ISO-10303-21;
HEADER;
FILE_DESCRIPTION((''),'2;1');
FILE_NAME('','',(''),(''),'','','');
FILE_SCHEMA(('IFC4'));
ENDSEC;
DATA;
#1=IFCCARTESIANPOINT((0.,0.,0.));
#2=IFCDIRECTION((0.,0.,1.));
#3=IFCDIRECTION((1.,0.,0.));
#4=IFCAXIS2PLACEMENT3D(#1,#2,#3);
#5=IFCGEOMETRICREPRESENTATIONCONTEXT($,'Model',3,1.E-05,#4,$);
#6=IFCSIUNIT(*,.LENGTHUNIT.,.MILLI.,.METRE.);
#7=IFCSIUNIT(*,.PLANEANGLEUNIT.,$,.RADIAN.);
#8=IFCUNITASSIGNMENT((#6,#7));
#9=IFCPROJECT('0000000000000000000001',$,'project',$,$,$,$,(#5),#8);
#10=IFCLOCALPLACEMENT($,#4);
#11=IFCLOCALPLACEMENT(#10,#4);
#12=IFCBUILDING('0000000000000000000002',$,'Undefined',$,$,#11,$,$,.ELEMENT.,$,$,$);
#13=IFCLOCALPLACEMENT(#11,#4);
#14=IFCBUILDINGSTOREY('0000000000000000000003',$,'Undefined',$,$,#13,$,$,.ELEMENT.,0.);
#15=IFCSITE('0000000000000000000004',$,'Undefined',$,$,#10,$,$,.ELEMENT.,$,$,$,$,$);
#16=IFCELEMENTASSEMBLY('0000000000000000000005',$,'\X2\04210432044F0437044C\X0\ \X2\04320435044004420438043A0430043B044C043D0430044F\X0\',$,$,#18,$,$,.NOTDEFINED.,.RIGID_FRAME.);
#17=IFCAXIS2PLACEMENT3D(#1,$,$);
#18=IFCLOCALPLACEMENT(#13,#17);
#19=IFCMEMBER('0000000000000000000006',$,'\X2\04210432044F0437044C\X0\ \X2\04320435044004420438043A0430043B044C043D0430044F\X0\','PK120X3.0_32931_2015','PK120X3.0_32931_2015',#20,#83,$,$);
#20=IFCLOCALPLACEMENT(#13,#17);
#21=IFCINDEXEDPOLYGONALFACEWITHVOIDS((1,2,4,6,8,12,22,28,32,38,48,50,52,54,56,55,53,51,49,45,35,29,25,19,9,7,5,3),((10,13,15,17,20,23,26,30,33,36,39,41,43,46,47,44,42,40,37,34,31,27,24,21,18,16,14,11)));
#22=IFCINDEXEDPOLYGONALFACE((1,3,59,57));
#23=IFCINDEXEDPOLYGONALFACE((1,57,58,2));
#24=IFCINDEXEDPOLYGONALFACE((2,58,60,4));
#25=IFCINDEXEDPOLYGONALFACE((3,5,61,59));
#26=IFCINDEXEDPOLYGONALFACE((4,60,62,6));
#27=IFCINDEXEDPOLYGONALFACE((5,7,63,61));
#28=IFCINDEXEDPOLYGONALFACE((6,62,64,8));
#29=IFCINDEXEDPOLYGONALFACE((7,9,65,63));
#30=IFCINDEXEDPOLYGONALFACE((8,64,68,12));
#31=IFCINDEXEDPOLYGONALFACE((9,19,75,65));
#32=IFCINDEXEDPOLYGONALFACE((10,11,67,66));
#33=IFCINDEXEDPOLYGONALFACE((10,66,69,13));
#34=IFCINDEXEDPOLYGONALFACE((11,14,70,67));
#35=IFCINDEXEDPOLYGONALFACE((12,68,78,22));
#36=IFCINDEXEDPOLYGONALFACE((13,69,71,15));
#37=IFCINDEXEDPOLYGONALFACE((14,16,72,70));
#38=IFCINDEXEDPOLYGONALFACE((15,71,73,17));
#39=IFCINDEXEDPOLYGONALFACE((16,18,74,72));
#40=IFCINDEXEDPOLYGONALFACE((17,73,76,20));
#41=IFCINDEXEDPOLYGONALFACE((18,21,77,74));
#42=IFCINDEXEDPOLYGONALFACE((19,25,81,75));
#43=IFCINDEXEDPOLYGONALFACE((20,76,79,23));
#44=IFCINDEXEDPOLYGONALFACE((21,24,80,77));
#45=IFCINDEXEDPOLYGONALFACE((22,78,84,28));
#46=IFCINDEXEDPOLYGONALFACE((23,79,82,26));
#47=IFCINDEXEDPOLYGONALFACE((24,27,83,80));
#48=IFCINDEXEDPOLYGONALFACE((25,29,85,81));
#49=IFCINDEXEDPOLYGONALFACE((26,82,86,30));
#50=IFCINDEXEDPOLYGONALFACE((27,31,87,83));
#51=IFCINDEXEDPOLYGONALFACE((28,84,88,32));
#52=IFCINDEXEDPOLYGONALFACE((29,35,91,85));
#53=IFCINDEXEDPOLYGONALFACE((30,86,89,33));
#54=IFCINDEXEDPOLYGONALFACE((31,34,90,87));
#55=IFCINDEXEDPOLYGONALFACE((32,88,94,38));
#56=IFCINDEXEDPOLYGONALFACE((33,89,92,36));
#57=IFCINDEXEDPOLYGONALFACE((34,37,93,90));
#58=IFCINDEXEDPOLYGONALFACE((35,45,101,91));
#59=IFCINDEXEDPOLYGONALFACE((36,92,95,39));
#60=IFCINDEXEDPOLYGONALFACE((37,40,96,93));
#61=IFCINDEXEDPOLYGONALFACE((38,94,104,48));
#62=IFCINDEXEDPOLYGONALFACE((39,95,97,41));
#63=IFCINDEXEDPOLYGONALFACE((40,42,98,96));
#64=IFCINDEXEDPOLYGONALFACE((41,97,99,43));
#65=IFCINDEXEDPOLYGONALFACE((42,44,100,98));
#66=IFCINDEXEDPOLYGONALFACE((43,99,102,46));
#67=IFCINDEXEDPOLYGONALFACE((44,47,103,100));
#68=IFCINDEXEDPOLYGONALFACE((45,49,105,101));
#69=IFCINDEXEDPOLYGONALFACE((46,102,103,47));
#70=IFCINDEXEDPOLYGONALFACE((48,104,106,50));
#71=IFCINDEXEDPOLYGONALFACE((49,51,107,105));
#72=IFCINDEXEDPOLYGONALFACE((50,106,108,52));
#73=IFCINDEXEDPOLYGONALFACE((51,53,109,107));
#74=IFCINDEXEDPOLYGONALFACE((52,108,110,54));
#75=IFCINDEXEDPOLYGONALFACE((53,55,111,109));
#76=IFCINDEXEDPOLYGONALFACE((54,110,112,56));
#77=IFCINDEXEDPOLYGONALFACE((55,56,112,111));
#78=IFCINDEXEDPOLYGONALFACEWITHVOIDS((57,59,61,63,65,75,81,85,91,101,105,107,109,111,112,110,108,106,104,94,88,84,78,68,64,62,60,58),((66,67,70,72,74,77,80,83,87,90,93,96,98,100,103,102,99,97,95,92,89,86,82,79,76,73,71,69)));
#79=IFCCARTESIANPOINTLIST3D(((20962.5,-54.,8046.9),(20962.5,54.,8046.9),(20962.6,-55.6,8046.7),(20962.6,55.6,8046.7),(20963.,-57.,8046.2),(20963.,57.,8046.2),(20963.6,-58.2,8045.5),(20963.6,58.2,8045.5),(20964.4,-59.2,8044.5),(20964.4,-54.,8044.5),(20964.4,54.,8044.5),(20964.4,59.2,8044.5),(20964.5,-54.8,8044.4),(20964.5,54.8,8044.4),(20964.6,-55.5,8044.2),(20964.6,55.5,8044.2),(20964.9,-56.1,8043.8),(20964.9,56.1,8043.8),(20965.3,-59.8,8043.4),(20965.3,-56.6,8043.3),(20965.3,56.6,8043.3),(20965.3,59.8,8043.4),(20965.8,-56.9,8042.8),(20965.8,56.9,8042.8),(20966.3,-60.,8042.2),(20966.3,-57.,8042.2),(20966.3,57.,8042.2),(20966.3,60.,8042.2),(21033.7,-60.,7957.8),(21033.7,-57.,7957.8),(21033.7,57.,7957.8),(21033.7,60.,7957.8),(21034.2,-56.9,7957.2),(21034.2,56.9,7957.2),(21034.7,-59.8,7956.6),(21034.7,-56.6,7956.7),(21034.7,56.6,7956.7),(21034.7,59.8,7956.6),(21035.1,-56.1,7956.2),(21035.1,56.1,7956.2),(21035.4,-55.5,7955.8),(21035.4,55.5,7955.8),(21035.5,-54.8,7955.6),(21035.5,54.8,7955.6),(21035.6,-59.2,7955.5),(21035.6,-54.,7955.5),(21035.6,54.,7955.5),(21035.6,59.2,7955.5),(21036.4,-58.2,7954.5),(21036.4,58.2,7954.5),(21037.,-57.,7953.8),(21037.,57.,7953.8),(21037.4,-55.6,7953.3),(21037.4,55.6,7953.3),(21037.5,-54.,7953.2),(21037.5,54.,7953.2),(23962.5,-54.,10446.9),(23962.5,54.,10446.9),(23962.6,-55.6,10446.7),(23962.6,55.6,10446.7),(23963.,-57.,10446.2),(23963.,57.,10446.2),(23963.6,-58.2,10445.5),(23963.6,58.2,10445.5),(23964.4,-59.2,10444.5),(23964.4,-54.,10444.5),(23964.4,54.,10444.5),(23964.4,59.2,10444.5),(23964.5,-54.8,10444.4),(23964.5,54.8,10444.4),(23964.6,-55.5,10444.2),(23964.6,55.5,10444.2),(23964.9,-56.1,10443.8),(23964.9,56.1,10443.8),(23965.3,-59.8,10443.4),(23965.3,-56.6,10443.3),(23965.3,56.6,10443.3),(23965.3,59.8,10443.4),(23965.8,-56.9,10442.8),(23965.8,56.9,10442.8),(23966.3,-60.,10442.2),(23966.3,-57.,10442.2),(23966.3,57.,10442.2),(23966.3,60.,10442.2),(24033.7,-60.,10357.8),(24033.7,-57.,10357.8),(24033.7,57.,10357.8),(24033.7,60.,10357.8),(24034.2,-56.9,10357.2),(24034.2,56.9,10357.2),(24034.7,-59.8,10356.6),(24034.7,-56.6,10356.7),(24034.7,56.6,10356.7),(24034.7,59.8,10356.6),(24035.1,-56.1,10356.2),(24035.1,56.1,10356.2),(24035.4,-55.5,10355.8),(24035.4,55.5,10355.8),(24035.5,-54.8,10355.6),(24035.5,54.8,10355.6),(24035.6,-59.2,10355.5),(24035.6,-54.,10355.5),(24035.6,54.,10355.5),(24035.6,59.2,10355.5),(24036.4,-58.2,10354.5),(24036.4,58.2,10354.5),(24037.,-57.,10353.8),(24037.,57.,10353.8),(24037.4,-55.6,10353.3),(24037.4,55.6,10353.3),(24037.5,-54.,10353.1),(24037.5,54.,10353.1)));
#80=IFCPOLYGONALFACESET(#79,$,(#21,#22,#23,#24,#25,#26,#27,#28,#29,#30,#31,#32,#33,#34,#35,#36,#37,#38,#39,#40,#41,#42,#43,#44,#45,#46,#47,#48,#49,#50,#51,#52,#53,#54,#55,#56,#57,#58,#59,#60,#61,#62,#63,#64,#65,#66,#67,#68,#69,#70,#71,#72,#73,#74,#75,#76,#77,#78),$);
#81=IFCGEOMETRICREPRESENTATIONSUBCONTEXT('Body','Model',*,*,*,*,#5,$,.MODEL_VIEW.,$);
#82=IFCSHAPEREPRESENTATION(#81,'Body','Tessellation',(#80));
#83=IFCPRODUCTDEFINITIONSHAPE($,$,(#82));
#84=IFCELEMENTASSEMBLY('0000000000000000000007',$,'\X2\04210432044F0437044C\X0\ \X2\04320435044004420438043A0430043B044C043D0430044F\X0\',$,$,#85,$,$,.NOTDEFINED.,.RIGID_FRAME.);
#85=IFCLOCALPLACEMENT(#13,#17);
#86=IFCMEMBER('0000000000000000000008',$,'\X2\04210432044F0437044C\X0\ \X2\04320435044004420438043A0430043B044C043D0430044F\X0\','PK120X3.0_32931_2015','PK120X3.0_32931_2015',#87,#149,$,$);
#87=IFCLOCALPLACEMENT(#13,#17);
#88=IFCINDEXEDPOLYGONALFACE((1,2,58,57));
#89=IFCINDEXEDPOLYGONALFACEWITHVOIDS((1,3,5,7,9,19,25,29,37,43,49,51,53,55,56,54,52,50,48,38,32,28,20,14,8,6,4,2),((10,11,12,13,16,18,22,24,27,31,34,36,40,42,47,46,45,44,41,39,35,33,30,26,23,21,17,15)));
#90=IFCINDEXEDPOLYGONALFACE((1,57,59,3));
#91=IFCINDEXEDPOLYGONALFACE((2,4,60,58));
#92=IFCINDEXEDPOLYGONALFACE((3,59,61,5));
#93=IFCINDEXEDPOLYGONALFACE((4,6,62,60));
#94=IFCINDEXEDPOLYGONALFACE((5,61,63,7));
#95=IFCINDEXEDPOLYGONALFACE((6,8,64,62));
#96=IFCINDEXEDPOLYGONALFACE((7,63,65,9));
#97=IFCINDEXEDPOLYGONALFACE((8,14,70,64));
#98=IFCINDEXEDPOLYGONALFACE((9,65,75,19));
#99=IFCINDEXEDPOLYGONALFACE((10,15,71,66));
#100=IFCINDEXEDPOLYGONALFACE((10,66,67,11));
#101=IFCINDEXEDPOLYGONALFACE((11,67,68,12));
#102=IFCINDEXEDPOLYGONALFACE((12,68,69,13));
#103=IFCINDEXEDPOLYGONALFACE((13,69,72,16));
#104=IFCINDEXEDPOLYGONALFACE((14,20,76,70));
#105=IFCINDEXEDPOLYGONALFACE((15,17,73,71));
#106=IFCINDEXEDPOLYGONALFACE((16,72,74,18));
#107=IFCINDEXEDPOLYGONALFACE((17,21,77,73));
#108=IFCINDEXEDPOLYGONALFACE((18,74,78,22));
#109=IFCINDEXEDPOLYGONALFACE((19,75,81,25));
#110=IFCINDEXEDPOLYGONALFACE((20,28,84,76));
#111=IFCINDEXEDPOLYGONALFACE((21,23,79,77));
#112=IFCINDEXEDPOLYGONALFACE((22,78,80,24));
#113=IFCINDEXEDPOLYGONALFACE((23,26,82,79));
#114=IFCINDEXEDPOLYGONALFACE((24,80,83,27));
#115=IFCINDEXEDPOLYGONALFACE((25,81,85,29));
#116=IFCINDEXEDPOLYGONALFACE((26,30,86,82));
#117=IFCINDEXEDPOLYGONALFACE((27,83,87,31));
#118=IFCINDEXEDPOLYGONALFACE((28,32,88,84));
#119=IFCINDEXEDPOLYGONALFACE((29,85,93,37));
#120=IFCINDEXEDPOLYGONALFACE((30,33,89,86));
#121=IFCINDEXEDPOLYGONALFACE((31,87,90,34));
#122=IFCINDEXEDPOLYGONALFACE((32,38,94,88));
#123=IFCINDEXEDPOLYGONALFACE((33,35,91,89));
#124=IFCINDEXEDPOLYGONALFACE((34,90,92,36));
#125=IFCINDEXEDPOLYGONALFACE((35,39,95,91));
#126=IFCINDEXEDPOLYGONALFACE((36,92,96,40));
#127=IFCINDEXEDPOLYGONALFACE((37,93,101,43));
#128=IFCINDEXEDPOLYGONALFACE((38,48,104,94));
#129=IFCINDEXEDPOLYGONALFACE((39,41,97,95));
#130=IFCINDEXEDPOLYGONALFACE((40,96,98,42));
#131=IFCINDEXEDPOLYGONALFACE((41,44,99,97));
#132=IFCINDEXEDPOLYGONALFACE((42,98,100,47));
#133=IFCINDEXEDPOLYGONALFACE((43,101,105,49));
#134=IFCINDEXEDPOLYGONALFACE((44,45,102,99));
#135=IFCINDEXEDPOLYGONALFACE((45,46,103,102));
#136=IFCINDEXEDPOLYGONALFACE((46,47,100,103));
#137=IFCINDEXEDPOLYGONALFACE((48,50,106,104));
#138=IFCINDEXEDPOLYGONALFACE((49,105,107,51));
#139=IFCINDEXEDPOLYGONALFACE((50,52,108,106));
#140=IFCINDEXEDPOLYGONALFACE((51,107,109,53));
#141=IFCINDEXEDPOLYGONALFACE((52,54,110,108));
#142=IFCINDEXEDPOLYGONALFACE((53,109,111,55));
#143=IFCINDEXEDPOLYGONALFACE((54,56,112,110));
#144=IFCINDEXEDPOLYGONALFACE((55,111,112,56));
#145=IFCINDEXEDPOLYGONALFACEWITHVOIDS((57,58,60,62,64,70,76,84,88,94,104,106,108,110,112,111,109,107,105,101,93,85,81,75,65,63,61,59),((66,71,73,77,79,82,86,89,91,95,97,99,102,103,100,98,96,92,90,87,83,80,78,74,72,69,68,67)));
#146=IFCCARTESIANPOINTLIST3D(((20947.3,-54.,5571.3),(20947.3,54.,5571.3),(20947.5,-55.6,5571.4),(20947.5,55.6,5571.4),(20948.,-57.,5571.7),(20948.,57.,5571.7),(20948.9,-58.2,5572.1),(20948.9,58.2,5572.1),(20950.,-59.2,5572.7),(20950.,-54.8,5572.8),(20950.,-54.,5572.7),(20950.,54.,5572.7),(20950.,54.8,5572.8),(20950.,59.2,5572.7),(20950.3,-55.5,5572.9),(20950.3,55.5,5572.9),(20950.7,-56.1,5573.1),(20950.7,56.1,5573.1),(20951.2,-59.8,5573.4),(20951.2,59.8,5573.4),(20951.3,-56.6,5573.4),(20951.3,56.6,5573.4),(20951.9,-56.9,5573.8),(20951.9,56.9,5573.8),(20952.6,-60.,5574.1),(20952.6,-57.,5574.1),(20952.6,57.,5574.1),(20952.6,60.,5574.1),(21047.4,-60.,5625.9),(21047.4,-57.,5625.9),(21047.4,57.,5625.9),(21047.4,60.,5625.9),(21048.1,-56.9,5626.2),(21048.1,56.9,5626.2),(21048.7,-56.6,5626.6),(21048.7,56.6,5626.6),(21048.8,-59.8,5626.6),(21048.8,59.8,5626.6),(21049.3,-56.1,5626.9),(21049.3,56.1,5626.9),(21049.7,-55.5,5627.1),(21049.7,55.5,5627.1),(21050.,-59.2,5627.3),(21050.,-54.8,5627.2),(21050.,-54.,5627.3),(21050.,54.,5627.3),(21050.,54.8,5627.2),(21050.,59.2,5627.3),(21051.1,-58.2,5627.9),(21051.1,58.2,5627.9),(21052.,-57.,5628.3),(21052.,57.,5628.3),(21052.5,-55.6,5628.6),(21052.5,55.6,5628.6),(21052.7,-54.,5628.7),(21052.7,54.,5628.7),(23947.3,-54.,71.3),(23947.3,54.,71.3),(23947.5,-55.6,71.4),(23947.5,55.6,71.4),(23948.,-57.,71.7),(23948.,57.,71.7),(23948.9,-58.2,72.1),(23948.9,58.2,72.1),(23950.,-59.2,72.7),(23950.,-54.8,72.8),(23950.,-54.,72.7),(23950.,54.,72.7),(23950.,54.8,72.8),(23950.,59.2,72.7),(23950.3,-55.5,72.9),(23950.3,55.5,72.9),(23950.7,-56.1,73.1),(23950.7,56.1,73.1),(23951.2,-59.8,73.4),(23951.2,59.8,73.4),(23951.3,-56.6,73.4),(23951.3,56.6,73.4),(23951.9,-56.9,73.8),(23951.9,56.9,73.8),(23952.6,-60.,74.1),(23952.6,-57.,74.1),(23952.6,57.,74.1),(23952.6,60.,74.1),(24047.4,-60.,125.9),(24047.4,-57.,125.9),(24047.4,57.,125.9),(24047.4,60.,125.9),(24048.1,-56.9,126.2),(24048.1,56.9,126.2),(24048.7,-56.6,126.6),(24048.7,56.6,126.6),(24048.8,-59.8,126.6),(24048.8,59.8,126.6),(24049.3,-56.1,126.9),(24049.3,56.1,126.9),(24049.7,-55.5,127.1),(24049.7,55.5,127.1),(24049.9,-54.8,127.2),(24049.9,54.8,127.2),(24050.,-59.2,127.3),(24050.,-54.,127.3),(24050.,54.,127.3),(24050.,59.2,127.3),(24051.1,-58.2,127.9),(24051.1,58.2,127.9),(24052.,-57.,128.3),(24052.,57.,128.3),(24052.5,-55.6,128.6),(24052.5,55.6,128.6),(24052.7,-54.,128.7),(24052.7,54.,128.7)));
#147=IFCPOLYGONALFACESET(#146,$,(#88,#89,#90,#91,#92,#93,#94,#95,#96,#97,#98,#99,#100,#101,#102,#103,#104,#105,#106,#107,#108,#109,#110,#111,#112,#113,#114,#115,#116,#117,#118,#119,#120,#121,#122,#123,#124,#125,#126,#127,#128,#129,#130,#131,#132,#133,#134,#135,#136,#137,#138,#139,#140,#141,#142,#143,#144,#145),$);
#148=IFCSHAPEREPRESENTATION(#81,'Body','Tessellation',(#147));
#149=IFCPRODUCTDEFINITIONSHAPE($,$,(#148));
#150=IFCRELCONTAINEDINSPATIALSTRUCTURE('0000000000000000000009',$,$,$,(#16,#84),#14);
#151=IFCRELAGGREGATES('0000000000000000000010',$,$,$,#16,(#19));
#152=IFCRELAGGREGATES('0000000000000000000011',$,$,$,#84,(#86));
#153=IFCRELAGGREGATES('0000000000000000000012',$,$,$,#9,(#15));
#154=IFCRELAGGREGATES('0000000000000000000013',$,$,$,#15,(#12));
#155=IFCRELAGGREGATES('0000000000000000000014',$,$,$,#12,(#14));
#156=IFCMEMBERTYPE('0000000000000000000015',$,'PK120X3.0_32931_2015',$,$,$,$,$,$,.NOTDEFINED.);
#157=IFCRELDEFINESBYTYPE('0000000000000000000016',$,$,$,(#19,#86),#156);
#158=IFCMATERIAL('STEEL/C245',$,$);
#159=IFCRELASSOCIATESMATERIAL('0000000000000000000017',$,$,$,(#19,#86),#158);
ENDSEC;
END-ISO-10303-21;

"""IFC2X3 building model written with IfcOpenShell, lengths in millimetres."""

from ifc_helpers import new_model, si_unit, frame, origin_with_axes, origin_2d_with_axis, place, context, subcontext, project, spatial, hollow_rectangle, extrude, material, type_object, element, aggregate, save


model = new_model("IFC2X3")

# Units and contexts
model_context = context("Model", 3, precision=1e-05, world=origin_with_axes())
body_context = subcontext(model_context, "Body", "Model", "MODEL_VIEW")
ifc_project = project(units=[si_unit("LENGTHUNIT", "METRE", prefix="MILLI"), si_unit("PLANEANGLEUNIT", "RADIAN")], contexts=[model_context])

# Site, building, storey
site_placement = place(None, origin_with_axes())
site = spatial("IfcSite", under=ifc_project, at=site_placement, Name="Undefined", CompositionType="ELEMENT")
building_placement = place(site_placement, origin_with_axes())
building = spatial("IfcBuilding", under=site, at=building_placement, Name="Undefined", CompositionType="ELEMENT")
storey_placement = place(building_placement, origin_with_axes())
storey = spatial("IfcBuildingStorey", under=building, at=storey_placement, Name="Undefined", CompositionType="ELEMENT", Elevation=0.0)

# Shared definitions
ifc_material_1 = material(Name="STEEL/C245")

# Element assemblies, members
member_type_1 = type_object("IfcMemberType", Name="PK120X3.0_32931_2015", PredefinedType="NOTDEFINED")
assembly_1_placement = place(storey_placement, origin_with_axes())
assembly_1 = element("IfcElementAssembly", 1, at=assembly_1_placement, inside=storey, Name="Связь вертикальная", AssemblyPlace="NOTDEFINED", PredefinedType="RIGID_FRAME")
member_1_placement = place(assembly_1_placement, frame((21000.0, 0.0, 8000.0), z_axis=(-0.624695, 0.0, 0.780869), x_axis=(0.780869, 0.0, 0.624695)))
member_1 = element("IfcMember", 2, at=member_1_placement, type_object=member_type_1, material=ifc_material_1, Name="Связь вертикальная", Description="PK120X3.0_32931_2015", ObjectType="PK120X3.0_32931_2015", context=body_context, shape_type="SweptSolid", body=[
    extrude(hollow_rectangle(XDim=120.0, YDim=120.0, WallThickness=3.0, InnerFilletRadius=3.0, OuterFilletRadius=6.0, at=origin_2d_with_axis()), frame((3841.9, 0.0, 0.0), z_axis=(-1.0, 0.0, 0.0), x_axis=(0.0, -1.0, 0.0)), (0.0, 0.0, 1.0), 3841.9),
])
aggregate(assembly_1, [member_1])
assembly_2_placement = place(storey_placement, origin_with_axes())
assembly_2 = element("IfcElementAssembly", 3, at=assembly_2_placement, inside=storey, Name="Связь вертикальная", AssemblyPlace="NOTDEFINED", PredefinedType="RIGID_FRAME")
member_2_placement = place(assembly_2_placement, frame((24000.0, 0.0, 100.0), z_axis=(0.877896, 0.0, 0.478852), x_axis=(-0.478852, 0.0, 0.877896)))
member_2 = element("IfcMember", 4, at=member_2_placement, type_object=member_type_1, material=ifc_material_1, Name="Связь вертикальная", Description="PK120X3.0_32931_2015", ObjectType="PK120X3.0_32931_2015", context=body_context, shape_type="SweptSolid", body=[
    extrude(hollow_rectangle(XDim=120.0, YDim=120.0, WallThickness=3.0, InnerFilletRadius=3.0, OuterFilletRadius=6.0, at=origin_2d_with_axis()), frame((6265.0, 0.0, 0.0), z_axis=(-1.0, 0.0, 0.0), x_axis=(0.0, -1.0, 0.0)), (0.0, 0.0, 1.0), 6265.0),
])
aggregate(assembly_2, [member_2])

save(model, "model.ifc")
